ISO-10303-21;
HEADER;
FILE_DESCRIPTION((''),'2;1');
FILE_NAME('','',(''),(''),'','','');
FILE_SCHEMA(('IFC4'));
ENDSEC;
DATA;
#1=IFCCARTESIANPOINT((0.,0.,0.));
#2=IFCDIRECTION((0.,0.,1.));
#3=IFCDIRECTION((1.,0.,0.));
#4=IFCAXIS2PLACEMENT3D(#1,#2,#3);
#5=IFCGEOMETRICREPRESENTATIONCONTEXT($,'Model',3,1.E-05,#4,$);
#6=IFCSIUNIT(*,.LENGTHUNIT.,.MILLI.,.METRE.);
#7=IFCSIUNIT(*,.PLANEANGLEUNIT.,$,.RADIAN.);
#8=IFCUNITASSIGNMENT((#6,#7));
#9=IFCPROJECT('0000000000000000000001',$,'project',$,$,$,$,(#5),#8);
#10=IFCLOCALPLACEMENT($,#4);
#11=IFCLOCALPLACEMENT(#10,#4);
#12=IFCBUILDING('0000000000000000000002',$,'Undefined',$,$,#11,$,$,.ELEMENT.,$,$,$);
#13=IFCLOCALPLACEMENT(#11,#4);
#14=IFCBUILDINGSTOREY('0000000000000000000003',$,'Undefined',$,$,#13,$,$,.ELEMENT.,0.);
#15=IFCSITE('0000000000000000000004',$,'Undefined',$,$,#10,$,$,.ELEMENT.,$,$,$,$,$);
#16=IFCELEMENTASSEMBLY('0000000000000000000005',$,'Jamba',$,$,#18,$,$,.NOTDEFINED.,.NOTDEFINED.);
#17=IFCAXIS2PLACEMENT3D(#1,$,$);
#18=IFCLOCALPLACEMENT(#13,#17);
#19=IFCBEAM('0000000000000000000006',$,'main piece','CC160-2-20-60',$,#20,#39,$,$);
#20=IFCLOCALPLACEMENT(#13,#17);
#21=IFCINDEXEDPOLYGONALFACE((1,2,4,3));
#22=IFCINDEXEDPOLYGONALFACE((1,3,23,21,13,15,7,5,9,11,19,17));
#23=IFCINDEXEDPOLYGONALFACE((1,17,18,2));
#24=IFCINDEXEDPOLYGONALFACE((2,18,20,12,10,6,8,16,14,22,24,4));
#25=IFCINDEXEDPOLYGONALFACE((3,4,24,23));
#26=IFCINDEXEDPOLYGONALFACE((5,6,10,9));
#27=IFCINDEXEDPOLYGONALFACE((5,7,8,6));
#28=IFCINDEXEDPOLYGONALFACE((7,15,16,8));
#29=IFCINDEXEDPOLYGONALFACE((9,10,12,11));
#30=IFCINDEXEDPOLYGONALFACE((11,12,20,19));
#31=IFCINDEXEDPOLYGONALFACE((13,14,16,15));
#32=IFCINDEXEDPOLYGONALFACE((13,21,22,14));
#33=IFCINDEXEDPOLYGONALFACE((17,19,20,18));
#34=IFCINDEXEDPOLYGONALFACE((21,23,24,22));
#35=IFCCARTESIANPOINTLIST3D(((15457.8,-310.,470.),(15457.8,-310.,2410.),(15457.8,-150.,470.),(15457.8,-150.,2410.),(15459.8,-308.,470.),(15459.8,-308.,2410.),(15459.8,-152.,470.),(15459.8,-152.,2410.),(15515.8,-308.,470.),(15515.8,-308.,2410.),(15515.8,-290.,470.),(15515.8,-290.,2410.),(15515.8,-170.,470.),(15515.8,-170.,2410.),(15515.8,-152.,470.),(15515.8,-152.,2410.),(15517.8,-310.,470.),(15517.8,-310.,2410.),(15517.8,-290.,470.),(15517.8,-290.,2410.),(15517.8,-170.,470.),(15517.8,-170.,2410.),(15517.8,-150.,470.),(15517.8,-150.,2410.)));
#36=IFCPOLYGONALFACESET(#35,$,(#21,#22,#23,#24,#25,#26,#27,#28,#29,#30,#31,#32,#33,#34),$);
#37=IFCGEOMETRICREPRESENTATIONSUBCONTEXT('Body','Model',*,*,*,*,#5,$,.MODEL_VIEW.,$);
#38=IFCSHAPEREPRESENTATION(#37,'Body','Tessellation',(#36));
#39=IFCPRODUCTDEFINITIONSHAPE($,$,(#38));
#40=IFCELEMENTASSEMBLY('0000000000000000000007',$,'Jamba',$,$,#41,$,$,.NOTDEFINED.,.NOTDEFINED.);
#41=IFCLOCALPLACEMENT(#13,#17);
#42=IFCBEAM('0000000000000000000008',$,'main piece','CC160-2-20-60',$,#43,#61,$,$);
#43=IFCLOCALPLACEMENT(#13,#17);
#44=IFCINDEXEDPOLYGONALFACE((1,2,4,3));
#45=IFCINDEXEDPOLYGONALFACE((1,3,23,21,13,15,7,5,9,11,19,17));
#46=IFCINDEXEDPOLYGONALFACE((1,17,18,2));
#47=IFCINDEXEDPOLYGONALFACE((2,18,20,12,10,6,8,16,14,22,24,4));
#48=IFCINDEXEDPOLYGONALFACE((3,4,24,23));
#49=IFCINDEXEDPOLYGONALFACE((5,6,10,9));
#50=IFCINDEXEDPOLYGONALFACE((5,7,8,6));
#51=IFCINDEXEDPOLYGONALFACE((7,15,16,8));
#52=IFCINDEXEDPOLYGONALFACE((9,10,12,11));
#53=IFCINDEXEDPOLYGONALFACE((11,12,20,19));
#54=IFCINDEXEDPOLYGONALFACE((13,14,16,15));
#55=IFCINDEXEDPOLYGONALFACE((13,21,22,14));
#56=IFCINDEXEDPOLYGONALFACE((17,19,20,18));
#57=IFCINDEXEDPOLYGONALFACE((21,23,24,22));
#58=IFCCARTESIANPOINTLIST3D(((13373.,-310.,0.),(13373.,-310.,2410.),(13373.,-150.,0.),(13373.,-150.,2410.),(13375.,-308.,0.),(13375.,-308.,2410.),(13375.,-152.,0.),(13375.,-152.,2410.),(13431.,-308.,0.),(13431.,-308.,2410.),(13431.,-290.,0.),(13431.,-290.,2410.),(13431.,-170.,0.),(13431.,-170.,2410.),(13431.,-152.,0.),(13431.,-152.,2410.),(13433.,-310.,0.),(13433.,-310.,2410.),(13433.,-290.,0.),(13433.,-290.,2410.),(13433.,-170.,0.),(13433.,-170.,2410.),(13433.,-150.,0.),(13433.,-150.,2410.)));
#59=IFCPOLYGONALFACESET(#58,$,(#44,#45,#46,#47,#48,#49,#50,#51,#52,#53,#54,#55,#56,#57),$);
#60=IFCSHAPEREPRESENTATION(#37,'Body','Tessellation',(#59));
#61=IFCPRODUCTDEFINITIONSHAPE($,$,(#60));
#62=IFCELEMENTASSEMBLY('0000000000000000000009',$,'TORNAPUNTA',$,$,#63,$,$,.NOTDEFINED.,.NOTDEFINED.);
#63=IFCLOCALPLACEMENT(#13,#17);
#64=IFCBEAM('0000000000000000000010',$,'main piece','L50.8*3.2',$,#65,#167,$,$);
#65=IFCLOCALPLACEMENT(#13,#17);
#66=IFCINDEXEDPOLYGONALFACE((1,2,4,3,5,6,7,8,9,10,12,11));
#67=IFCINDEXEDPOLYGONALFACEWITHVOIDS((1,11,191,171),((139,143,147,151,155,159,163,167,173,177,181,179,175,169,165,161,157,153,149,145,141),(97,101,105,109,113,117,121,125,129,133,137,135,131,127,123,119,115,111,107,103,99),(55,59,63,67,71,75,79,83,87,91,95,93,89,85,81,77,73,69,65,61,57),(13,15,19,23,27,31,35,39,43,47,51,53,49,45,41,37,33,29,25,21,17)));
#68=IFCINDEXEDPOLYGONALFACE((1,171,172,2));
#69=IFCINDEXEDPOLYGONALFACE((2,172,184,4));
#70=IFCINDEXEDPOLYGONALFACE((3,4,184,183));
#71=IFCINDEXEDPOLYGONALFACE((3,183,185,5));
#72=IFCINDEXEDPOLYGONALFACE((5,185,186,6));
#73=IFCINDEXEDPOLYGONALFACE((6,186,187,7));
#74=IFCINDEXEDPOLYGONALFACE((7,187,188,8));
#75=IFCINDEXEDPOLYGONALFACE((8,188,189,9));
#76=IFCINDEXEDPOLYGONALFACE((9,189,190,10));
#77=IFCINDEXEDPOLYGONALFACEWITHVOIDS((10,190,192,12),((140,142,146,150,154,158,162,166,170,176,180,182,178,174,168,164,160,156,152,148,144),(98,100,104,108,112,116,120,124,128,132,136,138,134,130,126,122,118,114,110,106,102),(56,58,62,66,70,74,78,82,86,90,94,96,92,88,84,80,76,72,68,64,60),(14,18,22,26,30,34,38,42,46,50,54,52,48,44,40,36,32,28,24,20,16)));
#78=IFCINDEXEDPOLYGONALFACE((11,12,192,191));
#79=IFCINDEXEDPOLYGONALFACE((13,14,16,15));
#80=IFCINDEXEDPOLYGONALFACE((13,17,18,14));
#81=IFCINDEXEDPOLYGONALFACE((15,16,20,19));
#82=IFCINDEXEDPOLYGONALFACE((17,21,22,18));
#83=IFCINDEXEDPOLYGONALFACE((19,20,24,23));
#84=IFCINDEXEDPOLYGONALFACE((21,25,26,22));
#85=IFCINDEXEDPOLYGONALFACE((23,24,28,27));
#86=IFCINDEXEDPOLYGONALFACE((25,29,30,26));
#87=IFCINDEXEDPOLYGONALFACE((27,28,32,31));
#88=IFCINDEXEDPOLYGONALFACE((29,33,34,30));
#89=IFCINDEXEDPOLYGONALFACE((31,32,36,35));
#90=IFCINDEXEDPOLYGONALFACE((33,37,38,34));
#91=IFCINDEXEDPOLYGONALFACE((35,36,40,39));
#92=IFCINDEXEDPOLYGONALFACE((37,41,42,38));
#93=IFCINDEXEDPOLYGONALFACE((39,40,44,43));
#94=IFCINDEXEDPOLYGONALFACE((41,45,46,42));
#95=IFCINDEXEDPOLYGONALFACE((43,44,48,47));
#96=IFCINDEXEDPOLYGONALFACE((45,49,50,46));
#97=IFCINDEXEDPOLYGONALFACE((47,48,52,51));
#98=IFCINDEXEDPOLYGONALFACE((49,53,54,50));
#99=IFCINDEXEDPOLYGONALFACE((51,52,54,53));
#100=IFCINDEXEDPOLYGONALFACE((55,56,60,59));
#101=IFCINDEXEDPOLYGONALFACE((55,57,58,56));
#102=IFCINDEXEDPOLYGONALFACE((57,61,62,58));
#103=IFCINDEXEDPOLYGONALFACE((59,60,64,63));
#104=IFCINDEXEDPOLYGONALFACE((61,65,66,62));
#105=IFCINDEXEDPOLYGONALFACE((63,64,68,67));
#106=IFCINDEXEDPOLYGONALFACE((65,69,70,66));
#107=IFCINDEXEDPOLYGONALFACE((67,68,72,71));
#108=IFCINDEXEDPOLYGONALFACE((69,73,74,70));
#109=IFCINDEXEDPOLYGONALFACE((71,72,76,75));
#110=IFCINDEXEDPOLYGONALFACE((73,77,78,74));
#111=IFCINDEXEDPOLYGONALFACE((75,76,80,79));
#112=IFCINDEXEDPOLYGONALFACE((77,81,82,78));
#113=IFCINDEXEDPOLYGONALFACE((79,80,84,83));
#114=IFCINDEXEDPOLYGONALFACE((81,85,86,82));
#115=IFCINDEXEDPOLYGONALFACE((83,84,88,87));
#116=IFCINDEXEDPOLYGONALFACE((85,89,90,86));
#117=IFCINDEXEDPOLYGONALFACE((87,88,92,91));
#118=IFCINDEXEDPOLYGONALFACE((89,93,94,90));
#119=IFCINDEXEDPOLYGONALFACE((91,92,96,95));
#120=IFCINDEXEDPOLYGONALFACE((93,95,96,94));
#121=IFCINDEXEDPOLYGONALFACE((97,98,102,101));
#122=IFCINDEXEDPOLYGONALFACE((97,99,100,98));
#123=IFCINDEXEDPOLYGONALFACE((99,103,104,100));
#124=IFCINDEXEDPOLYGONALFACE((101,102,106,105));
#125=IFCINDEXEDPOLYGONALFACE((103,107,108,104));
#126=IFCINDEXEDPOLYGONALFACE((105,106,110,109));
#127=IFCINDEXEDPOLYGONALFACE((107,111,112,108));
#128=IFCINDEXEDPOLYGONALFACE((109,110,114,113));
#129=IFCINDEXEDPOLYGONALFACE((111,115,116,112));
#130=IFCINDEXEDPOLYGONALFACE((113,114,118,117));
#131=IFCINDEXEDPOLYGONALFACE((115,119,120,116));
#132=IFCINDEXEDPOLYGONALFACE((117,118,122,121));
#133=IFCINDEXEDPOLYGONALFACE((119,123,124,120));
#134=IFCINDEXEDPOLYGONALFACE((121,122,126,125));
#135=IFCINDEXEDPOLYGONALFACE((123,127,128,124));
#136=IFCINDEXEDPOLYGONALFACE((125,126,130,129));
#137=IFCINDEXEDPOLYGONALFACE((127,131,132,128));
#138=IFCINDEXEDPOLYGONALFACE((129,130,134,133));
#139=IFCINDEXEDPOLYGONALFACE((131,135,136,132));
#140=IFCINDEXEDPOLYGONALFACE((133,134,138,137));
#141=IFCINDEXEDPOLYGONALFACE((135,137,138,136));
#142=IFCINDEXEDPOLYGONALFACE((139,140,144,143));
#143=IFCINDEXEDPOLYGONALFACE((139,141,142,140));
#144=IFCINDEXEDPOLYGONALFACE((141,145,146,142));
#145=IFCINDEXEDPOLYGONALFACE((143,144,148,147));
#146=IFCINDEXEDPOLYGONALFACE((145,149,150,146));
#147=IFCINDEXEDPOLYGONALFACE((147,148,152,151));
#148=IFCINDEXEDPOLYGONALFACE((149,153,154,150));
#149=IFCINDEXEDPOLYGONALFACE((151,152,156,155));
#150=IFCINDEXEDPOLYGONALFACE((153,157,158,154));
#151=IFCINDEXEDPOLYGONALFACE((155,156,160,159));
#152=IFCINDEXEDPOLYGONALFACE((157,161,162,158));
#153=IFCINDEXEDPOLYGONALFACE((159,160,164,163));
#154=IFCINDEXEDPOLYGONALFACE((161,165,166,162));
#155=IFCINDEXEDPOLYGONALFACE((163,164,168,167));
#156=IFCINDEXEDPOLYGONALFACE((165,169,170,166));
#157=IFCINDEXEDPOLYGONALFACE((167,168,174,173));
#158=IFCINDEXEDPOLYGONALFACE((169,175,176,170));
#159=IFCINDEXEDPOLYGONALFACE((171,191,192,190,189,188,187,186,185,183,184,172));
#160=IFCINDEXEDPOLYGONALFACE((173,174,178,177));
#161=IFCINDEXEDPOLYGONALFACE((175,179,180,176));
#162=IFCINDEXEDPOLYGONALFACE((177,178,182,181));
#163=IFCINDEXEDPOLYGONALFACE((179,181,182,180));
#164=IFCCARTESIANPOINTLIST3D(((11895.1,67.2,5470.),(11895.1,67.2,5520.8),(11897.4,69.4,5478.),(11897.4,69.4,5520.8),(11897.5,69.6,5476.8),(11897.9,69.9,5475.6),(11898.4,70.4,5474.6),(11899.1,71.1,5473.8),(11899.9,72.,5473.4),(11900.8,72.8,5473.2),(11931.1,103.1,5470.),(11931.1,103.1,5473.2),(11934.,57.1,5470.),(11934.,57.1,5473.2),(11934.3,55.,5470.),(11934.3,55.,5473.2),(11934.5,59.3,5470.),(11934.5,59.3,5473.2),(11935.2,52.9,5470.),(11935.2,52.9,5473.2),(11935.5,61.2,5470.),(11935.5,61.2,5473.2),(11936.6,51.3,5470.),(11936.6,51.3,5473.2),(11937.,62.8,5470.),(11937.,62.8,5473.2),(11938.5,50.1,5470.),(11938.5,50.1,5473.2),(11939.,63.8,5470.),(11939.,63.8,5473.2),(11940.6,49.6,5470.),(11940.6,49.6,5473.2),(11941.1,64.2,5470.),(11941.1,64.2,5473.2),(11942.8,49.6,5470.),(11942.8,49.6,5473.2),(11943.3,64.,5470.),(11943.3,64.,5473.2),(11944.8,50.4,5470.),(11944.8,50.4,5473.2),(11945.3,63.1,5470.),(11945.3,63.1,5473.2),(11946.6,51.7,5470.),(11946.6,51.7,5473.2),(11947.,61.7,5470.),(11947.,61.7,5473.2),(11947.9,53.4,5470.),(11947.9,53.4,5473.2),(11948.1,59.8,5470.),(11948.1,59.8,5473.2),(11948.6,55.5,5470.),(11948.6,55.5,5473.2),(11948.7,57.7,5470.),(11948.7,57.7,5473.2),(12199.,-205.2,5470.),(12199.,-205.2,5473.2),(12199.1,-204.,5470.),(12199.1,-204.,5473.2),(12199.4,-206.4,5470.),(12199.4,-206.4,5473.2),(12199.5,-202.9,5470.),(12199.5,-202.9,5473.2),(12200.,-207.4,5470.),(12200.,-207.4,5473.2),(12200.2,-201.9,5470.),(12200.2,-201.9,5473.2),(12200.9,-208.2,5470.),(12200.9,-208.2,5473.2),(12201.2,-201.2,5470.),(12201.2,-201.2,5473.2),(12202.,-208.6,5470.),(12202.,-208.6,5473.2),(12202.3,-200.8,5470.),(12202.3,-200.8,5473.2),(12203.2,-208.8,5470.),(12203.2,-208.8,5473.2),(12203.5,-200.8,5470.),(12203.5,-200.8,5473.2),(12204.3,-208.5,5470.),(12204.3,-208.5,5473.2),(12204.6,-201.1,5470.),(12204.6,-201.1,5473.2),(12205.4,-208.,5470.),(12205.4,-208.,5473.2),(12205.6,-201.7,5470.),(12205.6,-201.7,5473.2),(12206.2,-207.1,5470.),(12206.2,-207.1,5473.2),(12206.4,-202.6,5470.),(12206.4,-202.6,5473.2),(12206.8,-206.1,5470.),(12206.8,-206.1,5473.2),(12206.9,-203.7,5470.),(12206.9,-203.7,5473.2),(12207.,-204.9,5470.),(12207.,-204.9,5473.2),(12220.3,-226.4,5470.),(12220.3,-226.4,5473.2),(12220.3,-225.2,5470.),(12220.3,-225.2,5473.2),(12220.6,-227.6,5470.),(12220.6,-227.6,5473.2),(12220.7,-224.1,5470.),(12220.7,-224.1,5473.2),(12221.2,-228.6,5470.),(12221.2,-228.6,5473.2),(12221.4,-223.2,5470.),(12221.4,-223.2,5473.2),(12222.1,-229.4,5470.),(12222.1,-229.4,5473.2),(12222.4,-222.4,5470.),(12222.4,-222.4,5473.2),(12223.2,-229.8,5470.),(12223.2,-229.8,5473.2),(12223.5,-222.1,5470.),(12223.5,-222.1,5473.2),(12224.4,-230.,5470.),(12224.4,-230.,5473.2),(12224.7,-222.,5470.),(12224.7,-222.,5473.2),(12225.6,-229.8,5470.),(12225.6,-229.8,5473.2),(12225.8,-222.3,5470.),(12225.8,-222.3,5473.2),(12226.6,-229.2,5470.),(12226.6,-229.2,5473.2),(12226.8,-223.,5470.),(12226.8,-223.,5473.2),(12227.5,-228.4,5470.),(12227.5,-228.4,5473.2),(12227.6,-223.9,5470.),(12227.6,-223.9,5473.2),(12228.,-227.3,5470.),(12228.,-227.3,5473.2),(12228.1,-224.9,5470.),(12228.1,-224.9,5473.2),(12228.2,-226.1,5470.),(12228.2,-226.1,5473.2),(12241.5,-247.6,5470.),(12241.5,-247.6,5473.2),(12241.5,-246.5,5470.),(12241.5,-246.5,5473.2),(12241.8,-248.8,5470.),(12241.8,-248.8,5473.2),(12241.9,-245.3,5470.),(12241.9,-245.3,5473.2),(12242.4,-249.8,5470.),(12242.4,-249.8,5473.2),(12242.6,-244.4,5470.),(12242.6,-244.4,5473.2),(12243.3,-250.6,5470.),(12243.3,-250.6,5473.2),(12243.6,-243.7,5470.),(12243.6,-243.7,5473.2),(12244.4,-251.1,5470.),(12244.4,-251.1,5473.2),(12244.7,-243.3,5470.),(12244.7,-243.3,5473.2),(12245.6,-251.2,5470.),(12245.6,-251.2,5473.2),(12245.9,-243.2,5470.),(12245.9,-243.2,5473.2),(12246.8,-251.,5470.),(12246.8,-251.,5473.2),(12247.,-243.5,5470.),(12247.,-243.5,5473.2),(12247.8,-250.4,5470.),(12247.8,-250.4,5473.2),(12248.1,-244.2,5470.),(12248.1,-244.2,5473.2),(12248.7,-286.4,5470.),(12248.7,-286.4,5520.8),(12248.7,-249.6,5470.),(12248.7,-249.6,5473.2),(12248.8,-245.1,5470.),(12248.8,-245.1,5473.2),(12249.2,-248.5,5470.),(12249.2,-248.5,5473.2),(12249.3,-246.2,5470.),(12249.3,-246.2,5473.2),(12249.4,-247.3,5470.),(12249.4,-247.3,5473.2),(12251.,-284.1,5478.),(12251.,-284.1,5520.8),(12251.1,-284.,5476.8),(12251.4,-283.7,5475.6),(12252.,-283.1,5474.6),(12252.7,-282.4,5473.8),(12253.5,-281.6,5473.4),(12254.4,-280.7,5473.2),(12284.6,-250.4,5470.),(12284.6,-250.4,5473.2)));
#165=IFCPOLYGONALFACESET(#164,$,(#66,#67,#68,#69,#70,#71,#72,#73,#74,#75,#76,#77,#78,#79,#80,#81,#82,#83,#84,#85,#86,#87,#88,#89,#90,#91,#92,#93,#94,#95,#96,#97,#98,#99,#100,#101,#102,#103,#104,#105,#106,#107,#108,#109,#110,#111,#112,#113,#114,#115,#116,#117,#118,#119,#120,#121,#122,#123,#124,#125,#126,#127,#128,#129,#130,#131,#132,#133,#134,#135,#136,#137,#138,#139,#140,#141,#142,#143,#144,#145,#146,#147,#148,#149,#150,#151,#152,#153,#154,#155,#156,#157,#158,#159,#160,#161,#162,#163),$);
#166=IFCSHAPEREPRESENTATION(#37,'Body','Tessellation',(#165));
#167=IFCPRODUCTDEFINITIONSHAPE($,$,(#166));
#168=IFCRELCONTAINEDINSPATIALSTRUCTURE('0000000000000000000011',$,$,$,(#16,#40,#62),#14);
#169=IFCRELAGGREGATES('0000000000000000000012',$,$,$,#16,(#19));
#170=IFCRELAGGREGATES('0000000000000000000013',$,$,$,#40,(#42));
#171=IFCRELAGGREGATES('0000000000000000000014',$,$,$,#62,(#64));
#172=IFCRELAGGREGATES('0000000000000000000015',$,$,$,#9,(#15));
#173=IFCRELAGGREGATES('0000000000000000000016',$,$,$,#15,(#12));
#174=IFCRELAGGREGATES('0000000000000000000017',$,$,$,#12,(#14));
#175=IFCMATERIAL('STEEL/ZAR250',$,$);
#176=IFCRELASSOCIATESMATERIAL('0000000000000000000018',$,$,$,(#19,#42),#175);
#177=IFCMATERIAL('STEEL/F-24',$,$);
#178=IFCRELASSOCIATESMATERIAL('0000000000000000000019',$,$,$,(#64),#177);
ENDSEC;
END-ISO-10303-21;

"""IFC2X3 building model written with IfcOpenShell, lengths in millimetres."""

from ifc_helpers import new_model, si_unit, frame, origin_with_axes, origin_2d_with_axis, place, context, subcontext, project, spatial, circle, l_section, c_section, extrude, source, transform, mapped, material, element, aggregate, save


model = new_model("IFC2X3")

# Units and contexts
model_context = context("Model", 3, precision=1e-05, world=origin_with_axes())
body_context = subcontext(model_context, "Body", "Model", "MODEL_VIEW")
ifc_project = project(units=[si_unit("LENGTHUNIT", "METRE", prefix="MILLI"), si_unit("PLANEANGLEUNIT", "RADIAN")], contexts=[model_context])

# Site, building, storey
site_placement = place(None, origin_with_axes())
site = spatial("IfcSite", under=ifc_project, at=site_placement, Name="Undefined", CompositionType="ELEMENT")
building_placement = place(site_placement, origin_with_axes())
building = spatial("IfcBuilding", under=site, at=building_placement, Name="Undefined", CompositionType="ELEMENT")
storey_placement = place(building_placement, origin_with_axes())
storey = spatial("IfcBuildingStorey", under=building, at=storey_placement, Name="Undefined", CompositionType="ELEMENT", Elevation=0.0)

# Shared definitions
ifc_material_1 = material(Name="STEEL/F-24")

# Element assemblies, beams
assembly_1_placement = place(storey_placement, origin_with_axes())
assembly_1 = element("IfcElementAssembly", 1, at=assembly_1_placement, inside=storey, Name="Jamba", AssemblyPlace="NOTDEFINED", PredefinedType="NOTDEFINED")
ifc_material_2 = material(Name="STEEL/ZAR250")
beam_1_placement = place(assembly_1_placement, frame((15487.8, -230.0, 2410.0), z_axis=(0.0, 1.0, 0.0), x_axis=(0.000002, 0.0, -1.0)))
beam_1 = element("IfcBeam", 2, at=beam_1_placement, material=ifc_material_2, Name="main piece", Description="CC160-2-20-60", context=body_context, shape_type="SweptSolid", body=[
    extrude(c_section(Depth=160.0, Width=60.0, WallThickness=2.0, Girth=20.0, at=origin_2d_with_axis()), frame((1940.0, 0.0, 0.0), z_axis=(-1.0, 0.0, 0.0), x_axis=(0.0, -1.0, 0.0)), (0.0, 0.0, 1.0), 1940.0),
])
aggregate(assembly_1, [beam_1])
assembly_2_placement = place(storey_placement, origin_with_axes())
assembly_2 = element("IfcElementAssembly", 3, at=assembly_2_placement, inside=storey, Name="Jamba", AssemblyPlace="NOTDEFINED", PredefinedType="NOTDEFINED")
beam_2_placement = place(assembly_2_placement, frame((13403.0, -230.0, 2410.0), z_axis=(0.0, 1.0, 0.0), x_axis=(0.000002, 0.0, -1.0)))
beam_2 = element("IfcBeam", 4, at=beam_2_placement, material=ifc_material_2, Name="main piece", Description="CC160-2-20-60", context=body_context, shape_type="SweptSolid", body=[
    extrude(c_section(Depth=160.0, Width=60.0, WallThickness=2.0, Girth=20.0, at=origin_2d_with_axis()), frame((2410.0, 0.0, 0.0), z_axis=(-1.0, 0.0, 0.0), x_axis=(0.0, -1.0, 0.0)), (0.0, 0.0, 1.0), 2410.0),
])
aggregate(assembly_2, [beam_2])

# Element assembly, beam, openings
assembly_3_placement = place(storey_placement, origin_with_axes())
assembly_3 = element("IfcElementAssembly", 5, at=assembly_3_placement, inside=storey, Name="TORNAPUNTA", AssemblyPlace="NOTDEFINED", PredefinedType="NOTDEFINED")
beam_3_placement = place(assembly_3_placement, frame((12266.7, -268.4, 5495.4), z_axis=(0.0, 0.0, 1.0), x_axis=(-0.707107, 0.707107, 0.0)))
beam_3 = element("IfcBeam", 6, at=beam_3_placement, material=ifc_material_1, Name="main piece", Description="L50.8*3.2", context=body_context, shape_type="SweptSolid", body=[
    extrude(l_section(Depth=50.8, Width=50.8, Thickness=3.2, FilletRadius=4.8, at=origin_2d_with_axis()), frame((500.0, 0.0, 0.0), z_axis=(-1.0, 0.0, 0.0), x_axis=(0.0, -1.0, 0.0)), (0.0, 0.0, 1.0), 500.0),
])
shared_shape_1 = source(origin_with_axes(), body_context, "Body", "SweptSolid", [
    extrude(circle(Radius=4.0, at=origin_2d_with_axis()), frame((0.0, -3.3, 0.0), z_axis=(0.0, 1.0, 0.0), x_axis=(1.0, 0.0, 0.0)), (0.0, 0.0, 1.0), 3.4),
])
opening_1_placement = place(assembly_3_placement, frame((12245.4, -247.2, 5470.0), z_axis=(-0.707107, -0.707107, 0.0), x_axis=(-0.707107, 0.707107, 0.0)))
element("IfcOpeningElement", 7, at=opening_1_placement, cuts=beam_3, ObjectType="Opening", context=body_context, shape_type="MappedRepresentation", body=[
    mapped(shared_shape_1, transform((0.0, 0.0, 0.0))),
    mapped(shared_shape_1, transform((30.0, 0.0, 0.0))),
    mapped(shared_shape_1, transform((60.0, 0.0, 0.0))),
])
shared_shape_2 = source(origin_with_axes(), body_context, "Body", "SweptSolid", [
    extrude(circle(Radius=7.3, at=origin_2d_with_axis()), frame((0.0, -3.3, 0.0), z_axis=(0.0, 1.0, 0.0), x_axis=(1.0, 0.0, 0.0)), (0.0, 0.0, 1.0), 3.4),
])
opening_2_placement = place(assembly_3_placement, frame((11941.4, 56.9, 5470.0), z_axis=(0.707107, 0.707107, 0.0), x_axis=(0.707107, -0.707107, 0.0)))
element("IfcOpeningElement", 8, at=opening_2_placement, cuts=beam_3, ObjectType="Opening", context=body_context, shape_type="MappedRepresentation", body=[
    mapped(shared_shape_2, transform((0.0, 0.0, 0.0))),
])
aggregate(assembly_3, [beam_3])

save(model, "model.ifc")
